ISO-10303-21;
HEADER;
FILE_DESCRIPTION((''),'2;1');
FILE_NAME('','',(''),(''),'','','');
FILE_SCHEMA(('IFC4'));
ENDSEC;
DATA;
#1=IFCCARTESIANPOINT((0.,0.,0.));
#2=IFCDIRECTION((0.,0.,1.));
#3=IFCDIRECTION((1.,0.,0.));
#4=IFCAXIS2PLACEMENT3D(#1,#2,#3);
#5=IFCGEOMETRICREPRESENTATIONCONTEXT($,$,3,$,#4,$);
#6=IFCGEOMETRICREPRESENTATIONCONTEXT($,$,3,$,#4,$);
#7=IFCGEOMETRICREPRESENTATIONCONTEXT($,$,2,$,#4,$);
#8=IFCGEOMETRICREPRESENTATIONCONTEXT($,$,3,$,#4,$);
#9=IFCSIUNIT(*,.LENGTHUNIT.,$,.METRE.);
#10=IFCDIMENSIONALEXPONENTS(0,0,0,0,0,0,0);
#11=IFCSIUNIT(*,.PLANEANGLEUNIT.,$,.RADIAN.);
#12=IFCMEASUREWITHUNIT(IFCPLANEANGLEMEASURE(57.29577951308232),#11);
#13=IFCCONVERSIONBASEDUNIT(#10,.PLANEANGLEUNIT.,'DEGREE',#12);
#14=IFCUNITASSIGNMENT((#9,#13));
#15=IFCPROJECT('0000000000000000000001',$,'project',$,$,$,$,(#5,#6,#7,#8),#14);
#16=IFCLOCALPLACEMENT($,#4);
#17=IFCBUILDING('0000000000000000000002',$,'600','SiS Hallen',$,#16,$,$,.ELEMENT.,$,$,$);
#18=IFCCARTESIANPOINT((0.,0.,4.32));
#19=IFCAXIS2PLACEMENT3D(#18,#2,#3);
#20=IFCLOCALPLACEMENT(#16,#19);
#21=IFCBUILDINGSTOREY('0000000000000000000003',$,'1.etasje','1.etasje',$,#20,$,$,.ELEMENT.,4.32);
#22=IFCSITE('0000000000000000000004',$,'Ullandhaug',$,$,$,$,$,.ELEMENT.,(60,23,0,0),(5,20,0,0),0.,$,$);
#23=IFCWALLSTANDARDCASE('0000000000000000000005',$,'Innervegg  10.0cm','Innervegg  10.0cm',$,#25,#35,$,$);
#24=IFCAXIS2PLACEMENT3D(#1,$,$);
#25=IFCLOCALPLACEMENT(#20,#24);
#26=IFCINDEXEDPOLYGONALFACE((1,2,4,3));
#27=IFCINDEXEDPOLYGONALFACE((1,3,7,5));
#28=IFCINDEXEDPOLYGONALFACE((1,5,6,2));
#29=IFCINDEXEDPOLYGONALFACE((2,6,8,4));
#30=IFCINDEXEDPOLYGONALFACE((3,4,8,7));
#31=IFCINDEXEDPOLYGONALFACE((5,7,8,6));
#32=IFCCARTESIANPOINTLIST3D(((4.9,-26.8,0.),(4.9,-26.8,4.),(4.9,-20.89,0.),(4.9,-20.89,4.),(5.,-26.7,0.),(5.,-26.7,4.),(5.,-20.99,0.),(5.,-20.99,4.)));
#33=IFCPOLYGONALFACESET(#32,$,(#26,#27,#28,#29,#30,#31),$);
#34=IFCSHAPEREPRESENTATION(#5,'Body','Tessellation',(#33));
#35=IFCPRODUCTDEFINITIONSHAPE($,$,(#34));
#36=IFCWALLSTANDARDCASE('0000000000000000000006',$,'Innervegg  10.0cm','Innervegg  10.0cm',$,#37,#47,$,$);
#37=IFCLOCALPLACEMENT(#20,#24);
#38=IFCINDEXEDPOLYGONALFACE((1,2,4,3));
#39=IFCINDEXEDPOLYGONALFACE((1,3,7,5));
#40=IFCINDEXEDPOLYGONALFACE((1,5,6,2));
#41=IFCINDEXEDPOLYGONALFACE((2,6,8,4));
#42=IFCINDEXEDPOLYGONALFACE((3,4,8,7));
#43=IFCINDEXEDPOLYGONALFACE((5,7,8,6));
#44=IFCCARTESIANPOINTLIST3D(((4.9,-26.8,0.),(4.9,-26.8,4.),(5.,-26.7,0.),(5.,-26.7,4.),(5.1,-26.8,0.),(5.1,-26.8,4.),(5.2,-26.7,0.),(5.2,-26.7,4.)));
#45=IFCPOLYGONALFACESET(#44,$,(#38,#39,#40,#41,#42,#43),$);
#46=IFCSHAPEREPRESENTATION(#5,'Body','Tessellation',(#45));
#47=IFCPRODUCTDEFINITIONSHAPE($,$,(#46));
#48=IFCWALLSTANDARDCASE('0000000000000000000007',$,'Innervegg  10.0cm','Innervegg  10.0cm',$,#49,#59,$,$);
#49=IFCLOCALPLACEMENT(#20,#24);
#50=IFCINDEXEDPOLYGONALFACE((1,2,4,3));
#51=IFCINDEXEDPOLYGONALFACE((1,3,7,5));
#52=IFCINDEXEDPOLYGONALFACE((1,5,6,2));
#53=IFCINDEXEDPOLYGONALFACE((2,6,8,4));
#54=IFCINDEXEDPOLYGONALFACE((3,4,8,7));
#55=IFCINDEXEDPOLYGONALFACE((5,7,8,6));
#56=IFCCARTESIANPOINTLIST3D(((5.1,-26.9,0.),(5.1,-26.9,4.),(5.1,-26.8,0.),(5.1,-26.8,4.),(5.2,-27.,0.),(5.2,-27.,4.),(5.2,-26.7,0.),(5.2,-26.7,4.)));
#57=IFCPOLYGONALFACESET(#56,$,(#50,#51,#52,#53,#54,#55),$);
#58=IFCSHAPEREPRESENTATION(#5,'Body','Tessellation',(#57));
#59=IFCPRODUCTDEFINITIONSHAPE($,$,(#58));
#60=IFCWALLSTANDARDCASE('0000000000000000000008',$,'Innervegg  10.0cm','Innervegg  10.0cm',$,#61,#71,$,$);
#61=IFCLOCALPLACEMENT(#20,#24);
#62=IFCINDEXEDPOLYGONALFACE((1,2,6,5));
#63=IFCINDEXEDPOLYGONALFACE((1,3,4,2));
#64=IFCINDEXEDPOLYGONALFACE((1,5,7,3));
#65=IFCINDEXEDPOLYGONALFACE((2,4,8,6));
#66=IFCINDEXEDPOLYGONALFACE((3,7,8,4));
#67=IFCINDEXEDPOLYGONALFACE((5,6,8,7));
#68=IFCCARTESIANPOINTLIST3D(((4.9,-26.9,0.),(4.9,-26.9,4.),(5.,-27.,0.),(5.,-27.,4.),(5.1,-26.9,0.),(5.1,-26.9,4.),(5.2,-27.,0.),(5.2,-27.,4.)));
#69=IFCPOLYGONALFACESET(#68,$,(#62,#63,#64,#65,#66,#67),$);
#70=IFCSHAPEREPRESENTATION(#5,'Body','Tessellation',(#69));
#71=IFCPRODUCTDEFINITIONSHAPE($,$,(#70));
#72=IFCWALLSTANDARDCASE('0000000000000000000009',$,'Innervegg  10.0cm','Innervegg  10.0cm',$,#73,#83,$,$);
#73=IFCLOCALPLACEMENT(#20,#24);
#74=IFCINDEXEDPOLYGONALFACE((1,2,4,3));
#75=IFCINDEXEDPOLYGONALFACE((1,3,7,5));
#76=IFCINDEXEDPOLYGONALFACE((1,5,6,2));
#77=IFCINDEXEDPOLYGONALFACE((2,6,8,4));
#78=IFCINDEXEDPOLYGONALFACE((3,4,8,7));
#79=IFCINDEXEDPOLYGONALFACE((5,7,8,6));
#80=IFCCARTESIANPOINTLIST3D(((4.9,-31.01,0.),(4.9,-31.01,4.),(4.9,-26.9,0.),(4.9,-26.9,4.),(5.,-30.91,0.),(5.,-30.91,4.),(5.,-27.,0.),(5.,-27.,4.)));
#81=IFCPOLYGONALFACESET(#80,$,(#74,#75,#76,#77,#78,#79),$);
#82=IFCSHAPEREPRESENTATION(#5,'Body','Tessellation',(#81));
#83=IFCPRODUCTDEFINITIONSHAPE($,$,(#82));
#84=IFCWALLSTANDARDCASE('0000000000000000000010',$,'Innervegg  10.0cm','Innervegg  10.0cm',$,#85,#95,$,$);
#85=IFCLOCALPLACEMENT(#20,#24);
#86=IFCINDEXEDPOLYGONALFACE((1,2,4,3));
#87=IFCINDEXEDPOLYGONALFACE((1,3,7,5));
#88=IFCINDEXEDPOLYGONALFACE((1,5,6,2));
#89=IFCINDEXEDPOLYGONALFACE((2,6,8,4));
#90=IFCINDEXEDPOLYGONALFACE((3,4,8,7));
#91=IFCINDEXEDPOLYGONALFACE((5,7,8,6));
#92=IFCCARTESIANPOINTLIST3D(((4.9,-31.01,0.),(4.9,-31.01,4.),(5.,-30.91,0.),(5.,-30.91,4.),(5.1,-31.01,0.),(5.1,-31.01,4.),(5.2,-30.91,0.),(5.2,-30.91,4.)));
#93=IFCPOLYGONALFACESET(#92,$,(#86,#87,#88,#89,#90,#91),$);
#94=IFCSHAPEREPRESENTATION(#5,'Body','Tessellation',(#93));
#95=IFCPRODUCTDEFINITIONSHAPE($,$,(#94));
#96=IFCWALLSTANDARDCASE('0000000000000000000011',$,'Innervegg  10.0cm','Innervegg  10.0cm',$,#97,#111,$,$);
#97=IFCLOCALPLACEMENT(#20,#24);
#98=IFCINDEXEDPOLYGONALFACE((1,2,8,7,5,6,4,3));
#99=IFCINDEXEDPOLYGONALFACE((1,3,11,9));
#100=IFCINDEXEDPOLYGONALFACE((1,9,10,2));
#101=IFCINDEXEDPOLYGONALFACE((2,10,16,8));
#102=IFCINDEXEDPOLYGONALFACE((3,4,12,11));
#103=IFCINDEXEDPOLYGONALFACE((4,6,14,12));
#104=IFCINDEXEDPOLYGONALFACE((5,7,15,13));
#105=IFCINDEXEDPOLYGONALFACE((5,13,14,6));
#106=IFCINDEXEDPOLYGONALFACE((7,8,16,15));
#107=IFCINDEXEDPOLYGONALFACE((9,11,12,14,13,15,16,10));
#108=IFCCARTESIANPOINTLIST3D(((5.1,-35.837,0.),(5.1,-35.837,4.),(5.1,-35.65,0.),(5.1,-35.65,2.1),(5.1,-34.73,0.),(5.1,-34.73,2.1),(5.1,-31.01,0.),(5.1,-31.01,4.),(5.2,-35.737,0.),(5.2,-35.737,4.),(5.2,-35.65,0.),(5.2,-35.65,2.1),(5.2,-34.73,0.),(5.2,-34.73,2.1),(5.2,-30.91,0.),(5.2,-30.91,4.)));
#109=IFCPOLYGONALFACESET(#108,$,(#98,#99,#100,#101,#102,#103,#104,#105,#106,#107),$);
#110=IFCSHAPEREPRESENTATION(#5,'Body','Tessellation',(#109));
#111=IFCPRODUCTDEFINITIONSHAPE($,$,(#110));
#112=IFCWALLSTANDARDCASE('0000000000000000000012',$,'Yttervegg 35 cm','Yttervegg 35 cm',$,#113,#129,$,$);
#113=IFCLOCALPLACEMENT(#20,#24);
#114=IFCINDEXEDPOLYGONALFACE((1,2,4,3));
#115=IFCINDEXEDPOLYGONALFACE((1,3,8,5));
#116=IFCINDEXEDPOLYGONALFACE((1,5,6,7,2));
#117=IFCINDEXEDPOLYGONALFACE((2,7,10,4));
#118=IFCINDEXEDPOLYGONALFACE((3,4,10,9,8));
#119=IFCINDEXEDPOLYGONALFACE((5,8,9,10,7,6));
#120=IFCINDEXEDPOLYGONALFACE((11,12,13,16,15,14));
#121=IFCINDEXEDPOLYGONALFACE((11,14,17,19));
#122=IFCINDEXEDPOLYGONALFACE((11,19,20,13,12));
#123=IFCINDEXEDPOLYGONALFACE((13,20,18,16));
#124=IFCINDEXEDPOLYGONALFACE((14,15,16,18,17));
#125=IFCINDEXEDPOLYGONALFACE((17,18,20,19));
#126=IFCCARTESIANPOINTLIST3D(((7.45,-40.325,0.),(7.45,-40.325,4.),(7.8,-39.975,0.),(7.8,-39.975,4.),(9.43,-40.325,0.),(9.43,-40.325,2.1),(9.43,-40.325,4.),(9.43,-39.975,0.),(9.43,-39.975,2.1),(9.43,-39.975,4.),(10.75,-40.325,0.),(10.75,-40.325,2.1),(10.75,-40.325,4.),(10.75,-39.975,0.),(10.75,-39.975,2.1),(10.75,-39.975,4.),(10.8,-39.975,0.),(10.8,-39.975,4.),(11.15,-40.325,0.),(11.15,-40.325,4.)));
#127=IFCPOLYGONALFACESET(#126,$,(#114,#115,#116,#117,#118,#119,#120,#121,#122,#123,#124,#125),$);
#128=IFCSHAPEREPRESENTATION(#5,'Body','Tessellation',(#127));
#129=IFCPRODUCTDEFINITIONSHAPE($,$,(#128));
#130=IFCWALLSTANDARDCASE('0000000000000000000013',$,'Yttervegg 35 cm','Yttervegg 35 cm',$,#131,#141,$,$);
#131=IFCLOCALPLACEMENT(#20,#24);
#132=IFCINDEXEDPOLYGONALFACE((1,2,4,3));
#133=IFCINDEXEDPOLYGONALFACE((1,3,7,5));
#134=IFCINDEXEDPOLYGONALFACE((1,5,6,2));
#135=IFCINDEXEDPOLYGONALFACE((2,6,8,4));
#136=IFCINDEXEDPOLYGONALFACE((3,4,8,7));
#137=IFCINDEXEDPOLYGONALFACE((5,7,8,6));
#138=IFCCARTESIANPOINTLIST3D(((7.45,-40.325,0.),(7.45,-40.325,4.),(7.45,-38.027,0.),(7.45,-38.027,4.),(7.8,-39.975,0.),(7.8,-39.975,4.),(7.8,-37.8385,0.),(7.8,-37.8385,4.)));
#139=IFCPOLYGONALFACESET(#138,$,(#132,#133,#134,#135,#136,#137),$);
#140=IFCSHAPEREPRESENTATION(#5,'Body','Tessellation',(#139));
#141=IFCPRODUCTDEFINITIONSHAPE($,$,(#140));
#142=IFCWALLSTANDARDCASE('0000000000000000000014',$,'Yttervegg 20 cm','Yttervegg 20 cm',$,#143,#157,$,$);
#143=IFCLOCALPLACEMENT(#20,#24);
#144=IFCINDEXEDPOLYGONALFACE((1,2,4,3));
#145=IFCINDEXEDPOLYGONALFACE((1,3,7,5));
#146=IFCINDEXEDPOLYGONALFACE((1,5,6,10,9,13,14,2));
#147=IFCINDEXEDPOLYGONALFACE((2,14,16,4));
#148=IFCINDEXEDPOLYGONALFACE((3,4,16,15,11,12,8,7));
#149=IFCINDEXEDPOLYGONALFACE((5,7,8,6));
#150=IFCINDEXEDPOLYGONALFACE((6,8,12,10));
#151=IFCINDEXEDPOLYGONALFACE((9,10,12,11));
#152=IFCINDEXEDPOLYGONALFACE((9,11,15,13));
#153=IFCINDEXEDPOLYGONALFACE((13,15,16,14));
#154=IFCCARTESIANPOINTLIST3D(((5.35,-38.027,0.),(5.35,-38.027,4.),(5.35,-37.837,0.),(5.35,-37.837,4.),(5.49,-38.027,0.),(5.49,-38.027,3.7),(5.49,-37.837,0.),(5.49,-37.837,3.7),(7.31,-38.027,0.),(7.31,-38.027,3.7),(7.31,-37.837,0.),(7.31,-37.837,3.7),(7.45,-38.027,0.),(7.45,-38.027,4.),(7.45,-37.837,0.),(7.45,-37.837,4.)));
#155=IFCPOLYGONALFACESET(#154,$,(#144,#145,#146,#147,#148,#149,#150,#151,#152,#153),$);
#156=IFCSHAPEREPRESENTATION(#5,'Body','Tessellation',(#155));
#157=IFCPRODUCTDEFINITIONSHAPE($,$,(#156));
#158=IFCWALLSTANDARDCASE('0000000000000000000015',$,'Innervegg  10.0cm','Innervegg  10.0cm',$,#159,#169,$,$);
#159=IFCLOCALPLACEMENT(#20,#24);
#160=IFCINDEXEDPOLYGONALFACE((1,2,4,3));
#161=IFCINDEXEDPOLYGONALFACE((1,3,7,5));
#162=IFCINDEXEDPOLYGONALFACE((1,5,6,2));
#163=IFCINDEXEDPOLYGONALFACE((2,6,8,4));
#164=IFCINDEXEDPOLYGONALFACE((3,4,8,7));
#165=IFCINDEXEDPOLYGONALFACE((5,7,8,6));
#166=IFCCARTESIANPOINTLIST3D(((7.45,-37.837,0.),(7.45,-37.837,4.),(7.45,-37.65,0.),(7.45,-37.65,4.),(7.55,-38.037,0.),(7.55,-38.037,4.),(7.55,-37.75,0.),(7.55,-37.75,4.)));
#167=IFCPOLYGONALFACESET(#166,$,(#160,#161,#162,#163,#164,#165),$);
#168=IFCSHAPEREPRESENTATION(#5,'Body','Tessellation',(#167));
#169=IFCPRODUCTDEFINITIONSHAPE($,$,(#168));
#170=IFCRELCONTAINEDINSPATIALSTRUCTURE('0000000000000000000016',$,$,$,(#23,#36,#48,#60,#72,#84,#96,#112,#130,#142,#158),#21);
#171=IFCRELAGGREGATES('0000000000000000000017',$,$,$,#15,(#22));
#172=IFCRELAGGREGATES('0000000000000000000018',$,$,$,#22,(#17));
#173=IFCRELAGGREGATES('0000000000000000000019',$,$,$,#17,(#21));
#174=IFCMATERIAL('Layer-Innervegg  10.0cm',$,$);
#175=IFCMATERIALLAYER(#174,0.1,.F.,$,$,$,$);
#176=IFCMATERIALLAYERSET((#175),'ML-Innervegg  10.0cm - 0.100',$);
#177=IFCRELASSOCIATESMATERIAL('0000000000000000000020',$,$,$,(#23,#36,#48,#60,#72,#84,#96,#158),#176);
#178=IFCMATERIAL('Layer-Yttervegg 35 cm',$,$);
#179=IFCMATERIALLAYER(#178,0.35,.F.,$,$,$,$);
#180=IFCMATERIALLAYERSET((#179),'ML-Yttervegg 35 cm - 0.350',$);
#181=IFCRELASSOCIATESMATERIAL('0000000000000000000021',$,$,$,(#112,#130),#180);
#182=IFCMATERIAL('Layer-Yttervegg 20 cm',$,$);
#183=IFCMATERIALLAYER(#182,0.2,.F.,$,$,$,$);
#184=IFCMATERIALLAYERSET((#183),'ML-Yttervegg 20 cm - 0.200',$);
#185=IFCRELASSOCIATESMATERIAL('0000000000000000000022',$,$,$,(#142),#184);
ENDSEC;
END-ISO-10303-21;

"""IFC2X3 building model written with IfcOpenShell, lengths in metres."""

from ifc_helpers import new_model, entity, si_unit, converted_unit, frame, origin_with_axes, place, context, project, spatial, polyline, outline, extrude, material, layer, layer_set, layer_usage, element, save


model = new_model("IFC2X3")

# Units and contexts
context_of_model_1 = context(None, 3, world=origin_with_axes())
context_of_model_2 = context(None, 3, world=origin_with_axes())
context_of_model_3 = context(None, 2, world=origin_with_axes())
context_of_model_4 = context(None, 3, world=origin_with_axes())
ifc_project = project(units=[si_unit("LENGTHUNIT", "METRE"), converted_unit("PLANEANGLEUNIT", "DEGREE", entity("IfcPlaneAngleMeasure", 57.29577951308232), si_unit("PLANEANGLEUNIT", "RADIAN"), dimensions=[0, 0, 0, 0, 0, 0, 0])], contexts=[context_of_model_1, context_of_model_2, context_of_model_3, context_of_model_4])

# Site, building, storey
site = spatial("IfcSite", under=ifc_project, Name="Ullandhaug", CompositionType="ELEMENT", RefLatitude=(60, 23, 0, 0), RefLongitude=(5, 20, 0, 0), RefElevation=0.0)
building_placement = place(None, origin_with_axes())
building = spatial("IfcBuilding", under=site, at=building_placement, Name="600", Description="SiS Hallen", CompositionType="ELEMENT")
storey_placement = place(building_placement, frame((0.0, 0.0, 4.32), z_axis=(0.0, 0.0, 1.0), x_axis=(1.0, 0.0, 0.0)))
storey = spatial("IfcBuildingStorey", under=building, at=storey_placement, Name="1.etasje", Description="1.etasje", CompositionType="ELEMENT", Elevation=4.32)

# Shared definitions
ifc_material_1 = material(Name="Layer-Innervegg  10.0cm")
ifc_layer_1 = layer(ifc_material_1, 0.1, ventilated=False)
ifc_layer_set_1 = layer_set([ifc_layer_1], Name="ML-Innervegg  10.0cm - 0.100")
ifc_layer_usage_1 = layer_usage(ifc_layer_set_1, "AXIS2", "POSITIVE", 0.0)

# Walls
wall_1_placement = place(storey_placement, frame((4.9, -20.89, 0.0), z_axis=(0.0, 0.0, 1.0), x_axis=(0.0, -1.0, 0.0)))
element("IfcWallStandardCase", 1, at=wall_1_placement, inside=storey, material=ifc_layer_usage_1, Name="Innervegg  10.0cm", Description="Innervegg  10.0cm", context=context_of_model_1, shape_type="SweptSolid", body=[
    extrude(outline(polyline([(0.0, 0.0), (5.91, 0.0), (5.81, 0.1), (0.1, 0.1), (0.0, 0.0)])), frame((0.0, 0.0, 0.0), z_axis=(0.0, 0.0, 1.0), x_axis=(1.0, 0.0, 0.0)), (0.0, 0.0, 1.0), 4.0),
])
wall_2_placement = place(storey_placement, frame((4.9, -26.8, 0.0), z_axis=(0.0, 0.0, 1.0), x_axis=(1.0, 0.0, 0.0)))
element("IfcWallStandardCase", 2, at=wall_2_placement, inside=storey, material=ifc_layer_usage_1, Name="Innervegg  10.0cm", Description="Innervegg  10.0cm", context=context_of_model_1, shape_type="SweptSolid", body=[
    extrude(outline(polyline([(0.0, 0.0), (0.2, 0.0), (0.3, 0.1), (0.1, 0.1), (0.0, 0.0)])), origin_with_axes(), (0.0, 0.0, 1.0), 4.0),
])
wall_3_placement = place(storey_placement, frame((5.1, -26.8, 0.0), z_axis=(0.0, 0.0, 1.0), x_axis=(0.0, -1.0, 0.0)))
element("IfcWallStandardCase", 3, at=wall_3_placement, inside=storey, material=ifc_layer_usage_1, Name="Innervegg  10.0cm", Description="Innervegg  10.0cm", context=context_of_model_1, shape_type="SweptSolid", body=[
    extrude(outline(polyline([(0.0, 0.0), (0.1, 0.0), (0.2, 0.1), (-0.1, 0.1), (0.0, 0.0)])), frame((0.0, 0.0, 0.0), z_axis=(0.0, 0.0, 1.0), x_axis=(1.0, 0.0, 0.0)), (0.0, 0.0, 1.0), 4.0),
])
wall_4_placement = place(storey_placement, frame((5.1, -26.9, 0.0), z_axis=(0.0, 0.0, 1.0), x_axis=(-1.0, 0.0, 0.0)))
element("IfcWallStandardCase", 4, at=wall_4_placement, inside=storey, material=ifc_layer_usage_1, Name="Innervegg  10.0cm", Description="Innervegg  10.0cm", context=context_of_model_1, shape_type="SweptSolid", body=[
    extrude(outline(polyline([(0.0, 0.0), (0.2, 0.0), (0.1, 0.1), (-0.1, 0.1), (0.0, 0.0)])), frame((0.0, 0.0, 0.0), z_axis=(0.0, 0.0, 1.0), x_axis=(1.0, 0.0, 0.0)), (0.0, 0.0, 1.0), 4.0),
])
wall_5_placement = place(storey_placement, frame((4.9, -26.9, 0.0), z_axis=(0.0, 0.0, 1.0), x_axis=(0.0, -1.0, 0.0)))
element("IfcWallStandardCase", 5, at=wall_5_placement, inside=storey, material=ifc_layer_usage_1, Name="Innervegg  10.0cm", Description="Innervegg  10.0cm", context=context_of_model_1, shape_type="SweptSolid", body=[
    extrude(outline(polyline([(0.0, 0.0), (4.11, 0.0), (4.01, 0.1), (0.1, 0.1), (0.0, 0.0)])), frame((0.0, 0.0, 0.0), z_axis=(0.0, 0.0, 1.0), x_axis=(1.0, 0.0, 0.0)), (0.0, 0.0, 1.0), 4.0),
])
wall_6_placement = place(storey_placement, frame((4.9, -31.01, 0.0), z_axis=(0.0, 0.0, 1.0), x_axis=(1.0, 0.0, 0.0)))
element("IfcWallStandardCase", 6, at=wall_6_placement, inside=storey, material=ifc_layer_usage_1, Name="Innervegg  10.0cm", Description="Innervegg  10.0cm", context=context_of_model_1, shape_type="SweptSolid", body=[
    extrude(outline(polyline([(0.0, 0.0), (0.2, 0.0), (0.3, 0.1), (0.1, 0.1), (0.0, 0.0)])), origin_with_axes(), (0.0, 0.0, 1.0), 4.0),
])

# Wall, opening
wall_7_placement = place(storey_placement, frame((5.1, -31.01, 0.0), z_axis=(0.0, 0.0, 1.0), x_axis=(0.0, -1.0, 0.0)))
wall_7 = element("IfcWallStandardCase", 7, at=wall_7_placement, inside=storey, material=ifc_layer_usage_1, Name="Innervegg  10.0cm", Description="Innervegg  10.0cm", context=context_of_model_1, shape_type="SweptSolid", body=[
    extrude(outline(polyline([(0.0, 0.0), (4.827, 0.0), (4.727, 0.1), (-0.1, 0.1), (0.0, 0.0)])), frame((0.0, 0.0, 0.0), z_axis=(0.0, 0.0, 1.0), x_axis=(1.0, 0.0, 0.0)), (0.0, 0.0, 1.0), 4.0),
])
opening_1_placement = place(wall_7_placement, frame((3.72, 0.1, 0.0), z_axis=(0.0, 0.0, 1.0), x_axis=(1.0, 0.0, 0.0)))
element("IfcOpeningElement", 8, at=opening_1_placement, cuts=wall_7, context=context_of_model_1, shape_type="SweptSolid", body=[
    extrude(outline(polyline([(0.0, 0.0), (2.1, 0.0), (2.1, 0.92), (0.0, 0.92), (0.0, 0.0)])), frame((0.0, 0.0, 0.0), z_axis=(0.0, 1.0, 0.0), x_axis=(0.0, 0.0, 1.0)), (0.0, 0.0, -1.0), 0.1),
])

# Wall, openings
ifc_material_2 = material(Name="Layer-Yttervegg 35 cm")
ifc_layer_2 = layer(ifc_material_2, 0.35, ventilated=False)
ifc_layer_set_2 = layer_set([ifc_layer_2], Name="ML-Yttervegg 35 cm - 0.350")
ifc_layer_usage_2 = layer_usage(ifc_layer_set_2, "AXIS2", "POSITIVE", 0.0)
wall_8_placement = place(storey_placement, frame((7.45, -40.325, 0.0), z_axis=(0.0, 0.0, 1.0), x_axis=(1.0, 0.0, 0.0)))
wall_8 = element("IfcWallStandardCase", 9, at=wall_8_placement, inside=storey, material=ifc_layer_usage_2, Name="Yttervegg 35 cm", Description="Yttervegg 35 cm", context=context_of_model_1, shape_type="SweptSolid", body=[
    extrude(outline(polyline([(0.0, 0.0), (3.7, 0.0), (3.35, 0.35), (0.35, 0.35), (0.0, 0.0)])), origin_with_axes(), (0.0, 0.0, 1.0), 4.0),
])
opening_2_placement = place(wall_8_placement, frame((1.98, 0.35, 0.0), z_axis=(0.0, 0.0, 1.0), x_axis=(1.0, 0.0, 0.0)))
element("IfcOpeningElement", 10, at=opening_2_placement, cuts=wall_8, context=context_of_model_1, shape_type="SweptSolid", body=[
    extrude(outline(polyline([(0.0, 0.0), (2.1, 0.0), (2.1, 1.32), (0.0, 1.32), (0.0, 0.0)])), frame((0.0, 0.0, 0.0), z_axis=(0.0, 1.0, 0.0), x_axis=(0.0, 0.0, 1.0)), (0.0, 0.0, -1.0), 0.35),
])
opening_3_placement = place(wall_8_placement, frame((1.98, 0.35, 2.1), z_axis=(0.0, 0.0, 1.0), x_axis=(1.0, 0.0, 0.0)))
element("IfcOpeningElement", 11, at=opening_3_placement, cuts=wall_8, context=context_of_model_1, shape_type="SweptSolid", body=[
    extrude(outline(polyline([(0.0, 0.0), (1.9, 0.0), (1.9, 1.32), (0.0, 1.32), (0.0, 0.0)])), frame((0.0, 0.0, 0.0), z_axis=(0.0, 1.0, 0.0), x_axis=(0.0, 0.0, 1.0)), (0.0, 0.0, -1.0), 0.35),
])

# Wall
wall_9_placement = place(storey_placement, frame((7.45, -38.027, 0.0), z_axis=(0.0, 0.0, 1.0), x_axis=(0.0, -1.0, 0.0)))
element("IfcWallStandardCase", 12, at=wall_9_placement, inside=storey, material=ifc_layer_usage_2, Name="Yttervegg 35 cm", Description="Yttervegg 35 cm", context=context_of_model_1, shape_type="SweptSolid", body=[
    extrude(outline(polyline([(0.0, 0.0), (2.298, 0.0), (1.948, 0.35), (-0.1885, 0.35), (0.0, 0.0)])), frame((0.0, 0.0, 0.0), z_axis=(0.0, 0.0, 1.0), x_axis=(1.0, 0.0, 0.0)), (0.0, 0.0, 1.0), 4.0),
])

# Wall, opening
ifc_material_3 = material(Name="Layer-Yttervegg 20 cm")
ifc_layer_3 = layer(ifc_material_3, 0.2, ventilated=False)
ifc_layer_set_3 = layer_set([ifc_layer_3], Name="ML-Yttervegg 20 cm - 0.200")
ifc_layer_usage_3 = layer_usage(ifc_layer_set_3, "AXIS2", "POSITIVE", 0.0)
wall_10_placement = place(storey_placement, frame((5.35, -38.027, 0.0), z_axis=(0.0, 0.0, 1.0), x_axis=(1.0, 0.0, 0.0)))
wall_10 = element("IfcWallStandardCase", 13, at=wall_10_placement, inside=storey, material=ifc_layer_usage_3, Name="Yttervegg 20 cm", Description="Yttervegg 20 cm", context=context_of_model_1, shape_type="SweptSolid", body=[
    extrude(outline(polyline([(0.0, 0.0), (2.1, 0.0), (2.1, 0.19), (0.0, 0.19), (0.0, 0.0)])), origin_with_axes(), (0.0, 0.0, 1.0), 4.0),
])
opening_4_placement = place(wall_10_placement, frame((0.14, 0.19, 0.0), z_axis=(0.0, 0.0, 1.0), x_axis=(1.0, 0.0, 0.0)))
element("IfcOpeningElement", 14, at=opening_4_placement, cuts=wall_10, context=context_of_model_1, shape_type="SweptSolid", body=[
    extrude(outline(polyline([(0.0, 0.0), (3.7, 0.0), (3.7, 1.82), (0.0, 1.82), (0.0, 0.0)])), frame((0.0, 0.0, 0.0), z_axis=(0.0, 1.0, 0.0), x_axis=(0.0, 0.0, 1.0)), (0.0, 0.0, -1.0), 0.2),
])

# Wall
wall_11_placement = place(storey_placement, frame((7.55, -38.037, 0.0), z_axis=(0.0, 0.0, 1.0), x_axis=(0.0, 1.0, 0.0)))
element("IfcWallStandardCase", 15, at=wall_11_placement, inside=storey, material=ifc_layer_usage_1, Name="Innervegg  10.0cm", Description="Innervegg  10.0cm", context=context_of_model_1, shape_type="SweptSolid", body=[
    extrude(outline(polyline([(0.0, 0.0), (0.287, 0.0), (0.387, 0.1), (0.2, 0.1), (0.0, 0.0)])), frame((0.0, 0.0, 0.0), z_axis=(0.0, 0.0, 1.0), x_axis=(1.0, 0.0, 0.0)), (0.0, 0.0, 1.0), 4.0),
])

save(model, "model.ifc")
